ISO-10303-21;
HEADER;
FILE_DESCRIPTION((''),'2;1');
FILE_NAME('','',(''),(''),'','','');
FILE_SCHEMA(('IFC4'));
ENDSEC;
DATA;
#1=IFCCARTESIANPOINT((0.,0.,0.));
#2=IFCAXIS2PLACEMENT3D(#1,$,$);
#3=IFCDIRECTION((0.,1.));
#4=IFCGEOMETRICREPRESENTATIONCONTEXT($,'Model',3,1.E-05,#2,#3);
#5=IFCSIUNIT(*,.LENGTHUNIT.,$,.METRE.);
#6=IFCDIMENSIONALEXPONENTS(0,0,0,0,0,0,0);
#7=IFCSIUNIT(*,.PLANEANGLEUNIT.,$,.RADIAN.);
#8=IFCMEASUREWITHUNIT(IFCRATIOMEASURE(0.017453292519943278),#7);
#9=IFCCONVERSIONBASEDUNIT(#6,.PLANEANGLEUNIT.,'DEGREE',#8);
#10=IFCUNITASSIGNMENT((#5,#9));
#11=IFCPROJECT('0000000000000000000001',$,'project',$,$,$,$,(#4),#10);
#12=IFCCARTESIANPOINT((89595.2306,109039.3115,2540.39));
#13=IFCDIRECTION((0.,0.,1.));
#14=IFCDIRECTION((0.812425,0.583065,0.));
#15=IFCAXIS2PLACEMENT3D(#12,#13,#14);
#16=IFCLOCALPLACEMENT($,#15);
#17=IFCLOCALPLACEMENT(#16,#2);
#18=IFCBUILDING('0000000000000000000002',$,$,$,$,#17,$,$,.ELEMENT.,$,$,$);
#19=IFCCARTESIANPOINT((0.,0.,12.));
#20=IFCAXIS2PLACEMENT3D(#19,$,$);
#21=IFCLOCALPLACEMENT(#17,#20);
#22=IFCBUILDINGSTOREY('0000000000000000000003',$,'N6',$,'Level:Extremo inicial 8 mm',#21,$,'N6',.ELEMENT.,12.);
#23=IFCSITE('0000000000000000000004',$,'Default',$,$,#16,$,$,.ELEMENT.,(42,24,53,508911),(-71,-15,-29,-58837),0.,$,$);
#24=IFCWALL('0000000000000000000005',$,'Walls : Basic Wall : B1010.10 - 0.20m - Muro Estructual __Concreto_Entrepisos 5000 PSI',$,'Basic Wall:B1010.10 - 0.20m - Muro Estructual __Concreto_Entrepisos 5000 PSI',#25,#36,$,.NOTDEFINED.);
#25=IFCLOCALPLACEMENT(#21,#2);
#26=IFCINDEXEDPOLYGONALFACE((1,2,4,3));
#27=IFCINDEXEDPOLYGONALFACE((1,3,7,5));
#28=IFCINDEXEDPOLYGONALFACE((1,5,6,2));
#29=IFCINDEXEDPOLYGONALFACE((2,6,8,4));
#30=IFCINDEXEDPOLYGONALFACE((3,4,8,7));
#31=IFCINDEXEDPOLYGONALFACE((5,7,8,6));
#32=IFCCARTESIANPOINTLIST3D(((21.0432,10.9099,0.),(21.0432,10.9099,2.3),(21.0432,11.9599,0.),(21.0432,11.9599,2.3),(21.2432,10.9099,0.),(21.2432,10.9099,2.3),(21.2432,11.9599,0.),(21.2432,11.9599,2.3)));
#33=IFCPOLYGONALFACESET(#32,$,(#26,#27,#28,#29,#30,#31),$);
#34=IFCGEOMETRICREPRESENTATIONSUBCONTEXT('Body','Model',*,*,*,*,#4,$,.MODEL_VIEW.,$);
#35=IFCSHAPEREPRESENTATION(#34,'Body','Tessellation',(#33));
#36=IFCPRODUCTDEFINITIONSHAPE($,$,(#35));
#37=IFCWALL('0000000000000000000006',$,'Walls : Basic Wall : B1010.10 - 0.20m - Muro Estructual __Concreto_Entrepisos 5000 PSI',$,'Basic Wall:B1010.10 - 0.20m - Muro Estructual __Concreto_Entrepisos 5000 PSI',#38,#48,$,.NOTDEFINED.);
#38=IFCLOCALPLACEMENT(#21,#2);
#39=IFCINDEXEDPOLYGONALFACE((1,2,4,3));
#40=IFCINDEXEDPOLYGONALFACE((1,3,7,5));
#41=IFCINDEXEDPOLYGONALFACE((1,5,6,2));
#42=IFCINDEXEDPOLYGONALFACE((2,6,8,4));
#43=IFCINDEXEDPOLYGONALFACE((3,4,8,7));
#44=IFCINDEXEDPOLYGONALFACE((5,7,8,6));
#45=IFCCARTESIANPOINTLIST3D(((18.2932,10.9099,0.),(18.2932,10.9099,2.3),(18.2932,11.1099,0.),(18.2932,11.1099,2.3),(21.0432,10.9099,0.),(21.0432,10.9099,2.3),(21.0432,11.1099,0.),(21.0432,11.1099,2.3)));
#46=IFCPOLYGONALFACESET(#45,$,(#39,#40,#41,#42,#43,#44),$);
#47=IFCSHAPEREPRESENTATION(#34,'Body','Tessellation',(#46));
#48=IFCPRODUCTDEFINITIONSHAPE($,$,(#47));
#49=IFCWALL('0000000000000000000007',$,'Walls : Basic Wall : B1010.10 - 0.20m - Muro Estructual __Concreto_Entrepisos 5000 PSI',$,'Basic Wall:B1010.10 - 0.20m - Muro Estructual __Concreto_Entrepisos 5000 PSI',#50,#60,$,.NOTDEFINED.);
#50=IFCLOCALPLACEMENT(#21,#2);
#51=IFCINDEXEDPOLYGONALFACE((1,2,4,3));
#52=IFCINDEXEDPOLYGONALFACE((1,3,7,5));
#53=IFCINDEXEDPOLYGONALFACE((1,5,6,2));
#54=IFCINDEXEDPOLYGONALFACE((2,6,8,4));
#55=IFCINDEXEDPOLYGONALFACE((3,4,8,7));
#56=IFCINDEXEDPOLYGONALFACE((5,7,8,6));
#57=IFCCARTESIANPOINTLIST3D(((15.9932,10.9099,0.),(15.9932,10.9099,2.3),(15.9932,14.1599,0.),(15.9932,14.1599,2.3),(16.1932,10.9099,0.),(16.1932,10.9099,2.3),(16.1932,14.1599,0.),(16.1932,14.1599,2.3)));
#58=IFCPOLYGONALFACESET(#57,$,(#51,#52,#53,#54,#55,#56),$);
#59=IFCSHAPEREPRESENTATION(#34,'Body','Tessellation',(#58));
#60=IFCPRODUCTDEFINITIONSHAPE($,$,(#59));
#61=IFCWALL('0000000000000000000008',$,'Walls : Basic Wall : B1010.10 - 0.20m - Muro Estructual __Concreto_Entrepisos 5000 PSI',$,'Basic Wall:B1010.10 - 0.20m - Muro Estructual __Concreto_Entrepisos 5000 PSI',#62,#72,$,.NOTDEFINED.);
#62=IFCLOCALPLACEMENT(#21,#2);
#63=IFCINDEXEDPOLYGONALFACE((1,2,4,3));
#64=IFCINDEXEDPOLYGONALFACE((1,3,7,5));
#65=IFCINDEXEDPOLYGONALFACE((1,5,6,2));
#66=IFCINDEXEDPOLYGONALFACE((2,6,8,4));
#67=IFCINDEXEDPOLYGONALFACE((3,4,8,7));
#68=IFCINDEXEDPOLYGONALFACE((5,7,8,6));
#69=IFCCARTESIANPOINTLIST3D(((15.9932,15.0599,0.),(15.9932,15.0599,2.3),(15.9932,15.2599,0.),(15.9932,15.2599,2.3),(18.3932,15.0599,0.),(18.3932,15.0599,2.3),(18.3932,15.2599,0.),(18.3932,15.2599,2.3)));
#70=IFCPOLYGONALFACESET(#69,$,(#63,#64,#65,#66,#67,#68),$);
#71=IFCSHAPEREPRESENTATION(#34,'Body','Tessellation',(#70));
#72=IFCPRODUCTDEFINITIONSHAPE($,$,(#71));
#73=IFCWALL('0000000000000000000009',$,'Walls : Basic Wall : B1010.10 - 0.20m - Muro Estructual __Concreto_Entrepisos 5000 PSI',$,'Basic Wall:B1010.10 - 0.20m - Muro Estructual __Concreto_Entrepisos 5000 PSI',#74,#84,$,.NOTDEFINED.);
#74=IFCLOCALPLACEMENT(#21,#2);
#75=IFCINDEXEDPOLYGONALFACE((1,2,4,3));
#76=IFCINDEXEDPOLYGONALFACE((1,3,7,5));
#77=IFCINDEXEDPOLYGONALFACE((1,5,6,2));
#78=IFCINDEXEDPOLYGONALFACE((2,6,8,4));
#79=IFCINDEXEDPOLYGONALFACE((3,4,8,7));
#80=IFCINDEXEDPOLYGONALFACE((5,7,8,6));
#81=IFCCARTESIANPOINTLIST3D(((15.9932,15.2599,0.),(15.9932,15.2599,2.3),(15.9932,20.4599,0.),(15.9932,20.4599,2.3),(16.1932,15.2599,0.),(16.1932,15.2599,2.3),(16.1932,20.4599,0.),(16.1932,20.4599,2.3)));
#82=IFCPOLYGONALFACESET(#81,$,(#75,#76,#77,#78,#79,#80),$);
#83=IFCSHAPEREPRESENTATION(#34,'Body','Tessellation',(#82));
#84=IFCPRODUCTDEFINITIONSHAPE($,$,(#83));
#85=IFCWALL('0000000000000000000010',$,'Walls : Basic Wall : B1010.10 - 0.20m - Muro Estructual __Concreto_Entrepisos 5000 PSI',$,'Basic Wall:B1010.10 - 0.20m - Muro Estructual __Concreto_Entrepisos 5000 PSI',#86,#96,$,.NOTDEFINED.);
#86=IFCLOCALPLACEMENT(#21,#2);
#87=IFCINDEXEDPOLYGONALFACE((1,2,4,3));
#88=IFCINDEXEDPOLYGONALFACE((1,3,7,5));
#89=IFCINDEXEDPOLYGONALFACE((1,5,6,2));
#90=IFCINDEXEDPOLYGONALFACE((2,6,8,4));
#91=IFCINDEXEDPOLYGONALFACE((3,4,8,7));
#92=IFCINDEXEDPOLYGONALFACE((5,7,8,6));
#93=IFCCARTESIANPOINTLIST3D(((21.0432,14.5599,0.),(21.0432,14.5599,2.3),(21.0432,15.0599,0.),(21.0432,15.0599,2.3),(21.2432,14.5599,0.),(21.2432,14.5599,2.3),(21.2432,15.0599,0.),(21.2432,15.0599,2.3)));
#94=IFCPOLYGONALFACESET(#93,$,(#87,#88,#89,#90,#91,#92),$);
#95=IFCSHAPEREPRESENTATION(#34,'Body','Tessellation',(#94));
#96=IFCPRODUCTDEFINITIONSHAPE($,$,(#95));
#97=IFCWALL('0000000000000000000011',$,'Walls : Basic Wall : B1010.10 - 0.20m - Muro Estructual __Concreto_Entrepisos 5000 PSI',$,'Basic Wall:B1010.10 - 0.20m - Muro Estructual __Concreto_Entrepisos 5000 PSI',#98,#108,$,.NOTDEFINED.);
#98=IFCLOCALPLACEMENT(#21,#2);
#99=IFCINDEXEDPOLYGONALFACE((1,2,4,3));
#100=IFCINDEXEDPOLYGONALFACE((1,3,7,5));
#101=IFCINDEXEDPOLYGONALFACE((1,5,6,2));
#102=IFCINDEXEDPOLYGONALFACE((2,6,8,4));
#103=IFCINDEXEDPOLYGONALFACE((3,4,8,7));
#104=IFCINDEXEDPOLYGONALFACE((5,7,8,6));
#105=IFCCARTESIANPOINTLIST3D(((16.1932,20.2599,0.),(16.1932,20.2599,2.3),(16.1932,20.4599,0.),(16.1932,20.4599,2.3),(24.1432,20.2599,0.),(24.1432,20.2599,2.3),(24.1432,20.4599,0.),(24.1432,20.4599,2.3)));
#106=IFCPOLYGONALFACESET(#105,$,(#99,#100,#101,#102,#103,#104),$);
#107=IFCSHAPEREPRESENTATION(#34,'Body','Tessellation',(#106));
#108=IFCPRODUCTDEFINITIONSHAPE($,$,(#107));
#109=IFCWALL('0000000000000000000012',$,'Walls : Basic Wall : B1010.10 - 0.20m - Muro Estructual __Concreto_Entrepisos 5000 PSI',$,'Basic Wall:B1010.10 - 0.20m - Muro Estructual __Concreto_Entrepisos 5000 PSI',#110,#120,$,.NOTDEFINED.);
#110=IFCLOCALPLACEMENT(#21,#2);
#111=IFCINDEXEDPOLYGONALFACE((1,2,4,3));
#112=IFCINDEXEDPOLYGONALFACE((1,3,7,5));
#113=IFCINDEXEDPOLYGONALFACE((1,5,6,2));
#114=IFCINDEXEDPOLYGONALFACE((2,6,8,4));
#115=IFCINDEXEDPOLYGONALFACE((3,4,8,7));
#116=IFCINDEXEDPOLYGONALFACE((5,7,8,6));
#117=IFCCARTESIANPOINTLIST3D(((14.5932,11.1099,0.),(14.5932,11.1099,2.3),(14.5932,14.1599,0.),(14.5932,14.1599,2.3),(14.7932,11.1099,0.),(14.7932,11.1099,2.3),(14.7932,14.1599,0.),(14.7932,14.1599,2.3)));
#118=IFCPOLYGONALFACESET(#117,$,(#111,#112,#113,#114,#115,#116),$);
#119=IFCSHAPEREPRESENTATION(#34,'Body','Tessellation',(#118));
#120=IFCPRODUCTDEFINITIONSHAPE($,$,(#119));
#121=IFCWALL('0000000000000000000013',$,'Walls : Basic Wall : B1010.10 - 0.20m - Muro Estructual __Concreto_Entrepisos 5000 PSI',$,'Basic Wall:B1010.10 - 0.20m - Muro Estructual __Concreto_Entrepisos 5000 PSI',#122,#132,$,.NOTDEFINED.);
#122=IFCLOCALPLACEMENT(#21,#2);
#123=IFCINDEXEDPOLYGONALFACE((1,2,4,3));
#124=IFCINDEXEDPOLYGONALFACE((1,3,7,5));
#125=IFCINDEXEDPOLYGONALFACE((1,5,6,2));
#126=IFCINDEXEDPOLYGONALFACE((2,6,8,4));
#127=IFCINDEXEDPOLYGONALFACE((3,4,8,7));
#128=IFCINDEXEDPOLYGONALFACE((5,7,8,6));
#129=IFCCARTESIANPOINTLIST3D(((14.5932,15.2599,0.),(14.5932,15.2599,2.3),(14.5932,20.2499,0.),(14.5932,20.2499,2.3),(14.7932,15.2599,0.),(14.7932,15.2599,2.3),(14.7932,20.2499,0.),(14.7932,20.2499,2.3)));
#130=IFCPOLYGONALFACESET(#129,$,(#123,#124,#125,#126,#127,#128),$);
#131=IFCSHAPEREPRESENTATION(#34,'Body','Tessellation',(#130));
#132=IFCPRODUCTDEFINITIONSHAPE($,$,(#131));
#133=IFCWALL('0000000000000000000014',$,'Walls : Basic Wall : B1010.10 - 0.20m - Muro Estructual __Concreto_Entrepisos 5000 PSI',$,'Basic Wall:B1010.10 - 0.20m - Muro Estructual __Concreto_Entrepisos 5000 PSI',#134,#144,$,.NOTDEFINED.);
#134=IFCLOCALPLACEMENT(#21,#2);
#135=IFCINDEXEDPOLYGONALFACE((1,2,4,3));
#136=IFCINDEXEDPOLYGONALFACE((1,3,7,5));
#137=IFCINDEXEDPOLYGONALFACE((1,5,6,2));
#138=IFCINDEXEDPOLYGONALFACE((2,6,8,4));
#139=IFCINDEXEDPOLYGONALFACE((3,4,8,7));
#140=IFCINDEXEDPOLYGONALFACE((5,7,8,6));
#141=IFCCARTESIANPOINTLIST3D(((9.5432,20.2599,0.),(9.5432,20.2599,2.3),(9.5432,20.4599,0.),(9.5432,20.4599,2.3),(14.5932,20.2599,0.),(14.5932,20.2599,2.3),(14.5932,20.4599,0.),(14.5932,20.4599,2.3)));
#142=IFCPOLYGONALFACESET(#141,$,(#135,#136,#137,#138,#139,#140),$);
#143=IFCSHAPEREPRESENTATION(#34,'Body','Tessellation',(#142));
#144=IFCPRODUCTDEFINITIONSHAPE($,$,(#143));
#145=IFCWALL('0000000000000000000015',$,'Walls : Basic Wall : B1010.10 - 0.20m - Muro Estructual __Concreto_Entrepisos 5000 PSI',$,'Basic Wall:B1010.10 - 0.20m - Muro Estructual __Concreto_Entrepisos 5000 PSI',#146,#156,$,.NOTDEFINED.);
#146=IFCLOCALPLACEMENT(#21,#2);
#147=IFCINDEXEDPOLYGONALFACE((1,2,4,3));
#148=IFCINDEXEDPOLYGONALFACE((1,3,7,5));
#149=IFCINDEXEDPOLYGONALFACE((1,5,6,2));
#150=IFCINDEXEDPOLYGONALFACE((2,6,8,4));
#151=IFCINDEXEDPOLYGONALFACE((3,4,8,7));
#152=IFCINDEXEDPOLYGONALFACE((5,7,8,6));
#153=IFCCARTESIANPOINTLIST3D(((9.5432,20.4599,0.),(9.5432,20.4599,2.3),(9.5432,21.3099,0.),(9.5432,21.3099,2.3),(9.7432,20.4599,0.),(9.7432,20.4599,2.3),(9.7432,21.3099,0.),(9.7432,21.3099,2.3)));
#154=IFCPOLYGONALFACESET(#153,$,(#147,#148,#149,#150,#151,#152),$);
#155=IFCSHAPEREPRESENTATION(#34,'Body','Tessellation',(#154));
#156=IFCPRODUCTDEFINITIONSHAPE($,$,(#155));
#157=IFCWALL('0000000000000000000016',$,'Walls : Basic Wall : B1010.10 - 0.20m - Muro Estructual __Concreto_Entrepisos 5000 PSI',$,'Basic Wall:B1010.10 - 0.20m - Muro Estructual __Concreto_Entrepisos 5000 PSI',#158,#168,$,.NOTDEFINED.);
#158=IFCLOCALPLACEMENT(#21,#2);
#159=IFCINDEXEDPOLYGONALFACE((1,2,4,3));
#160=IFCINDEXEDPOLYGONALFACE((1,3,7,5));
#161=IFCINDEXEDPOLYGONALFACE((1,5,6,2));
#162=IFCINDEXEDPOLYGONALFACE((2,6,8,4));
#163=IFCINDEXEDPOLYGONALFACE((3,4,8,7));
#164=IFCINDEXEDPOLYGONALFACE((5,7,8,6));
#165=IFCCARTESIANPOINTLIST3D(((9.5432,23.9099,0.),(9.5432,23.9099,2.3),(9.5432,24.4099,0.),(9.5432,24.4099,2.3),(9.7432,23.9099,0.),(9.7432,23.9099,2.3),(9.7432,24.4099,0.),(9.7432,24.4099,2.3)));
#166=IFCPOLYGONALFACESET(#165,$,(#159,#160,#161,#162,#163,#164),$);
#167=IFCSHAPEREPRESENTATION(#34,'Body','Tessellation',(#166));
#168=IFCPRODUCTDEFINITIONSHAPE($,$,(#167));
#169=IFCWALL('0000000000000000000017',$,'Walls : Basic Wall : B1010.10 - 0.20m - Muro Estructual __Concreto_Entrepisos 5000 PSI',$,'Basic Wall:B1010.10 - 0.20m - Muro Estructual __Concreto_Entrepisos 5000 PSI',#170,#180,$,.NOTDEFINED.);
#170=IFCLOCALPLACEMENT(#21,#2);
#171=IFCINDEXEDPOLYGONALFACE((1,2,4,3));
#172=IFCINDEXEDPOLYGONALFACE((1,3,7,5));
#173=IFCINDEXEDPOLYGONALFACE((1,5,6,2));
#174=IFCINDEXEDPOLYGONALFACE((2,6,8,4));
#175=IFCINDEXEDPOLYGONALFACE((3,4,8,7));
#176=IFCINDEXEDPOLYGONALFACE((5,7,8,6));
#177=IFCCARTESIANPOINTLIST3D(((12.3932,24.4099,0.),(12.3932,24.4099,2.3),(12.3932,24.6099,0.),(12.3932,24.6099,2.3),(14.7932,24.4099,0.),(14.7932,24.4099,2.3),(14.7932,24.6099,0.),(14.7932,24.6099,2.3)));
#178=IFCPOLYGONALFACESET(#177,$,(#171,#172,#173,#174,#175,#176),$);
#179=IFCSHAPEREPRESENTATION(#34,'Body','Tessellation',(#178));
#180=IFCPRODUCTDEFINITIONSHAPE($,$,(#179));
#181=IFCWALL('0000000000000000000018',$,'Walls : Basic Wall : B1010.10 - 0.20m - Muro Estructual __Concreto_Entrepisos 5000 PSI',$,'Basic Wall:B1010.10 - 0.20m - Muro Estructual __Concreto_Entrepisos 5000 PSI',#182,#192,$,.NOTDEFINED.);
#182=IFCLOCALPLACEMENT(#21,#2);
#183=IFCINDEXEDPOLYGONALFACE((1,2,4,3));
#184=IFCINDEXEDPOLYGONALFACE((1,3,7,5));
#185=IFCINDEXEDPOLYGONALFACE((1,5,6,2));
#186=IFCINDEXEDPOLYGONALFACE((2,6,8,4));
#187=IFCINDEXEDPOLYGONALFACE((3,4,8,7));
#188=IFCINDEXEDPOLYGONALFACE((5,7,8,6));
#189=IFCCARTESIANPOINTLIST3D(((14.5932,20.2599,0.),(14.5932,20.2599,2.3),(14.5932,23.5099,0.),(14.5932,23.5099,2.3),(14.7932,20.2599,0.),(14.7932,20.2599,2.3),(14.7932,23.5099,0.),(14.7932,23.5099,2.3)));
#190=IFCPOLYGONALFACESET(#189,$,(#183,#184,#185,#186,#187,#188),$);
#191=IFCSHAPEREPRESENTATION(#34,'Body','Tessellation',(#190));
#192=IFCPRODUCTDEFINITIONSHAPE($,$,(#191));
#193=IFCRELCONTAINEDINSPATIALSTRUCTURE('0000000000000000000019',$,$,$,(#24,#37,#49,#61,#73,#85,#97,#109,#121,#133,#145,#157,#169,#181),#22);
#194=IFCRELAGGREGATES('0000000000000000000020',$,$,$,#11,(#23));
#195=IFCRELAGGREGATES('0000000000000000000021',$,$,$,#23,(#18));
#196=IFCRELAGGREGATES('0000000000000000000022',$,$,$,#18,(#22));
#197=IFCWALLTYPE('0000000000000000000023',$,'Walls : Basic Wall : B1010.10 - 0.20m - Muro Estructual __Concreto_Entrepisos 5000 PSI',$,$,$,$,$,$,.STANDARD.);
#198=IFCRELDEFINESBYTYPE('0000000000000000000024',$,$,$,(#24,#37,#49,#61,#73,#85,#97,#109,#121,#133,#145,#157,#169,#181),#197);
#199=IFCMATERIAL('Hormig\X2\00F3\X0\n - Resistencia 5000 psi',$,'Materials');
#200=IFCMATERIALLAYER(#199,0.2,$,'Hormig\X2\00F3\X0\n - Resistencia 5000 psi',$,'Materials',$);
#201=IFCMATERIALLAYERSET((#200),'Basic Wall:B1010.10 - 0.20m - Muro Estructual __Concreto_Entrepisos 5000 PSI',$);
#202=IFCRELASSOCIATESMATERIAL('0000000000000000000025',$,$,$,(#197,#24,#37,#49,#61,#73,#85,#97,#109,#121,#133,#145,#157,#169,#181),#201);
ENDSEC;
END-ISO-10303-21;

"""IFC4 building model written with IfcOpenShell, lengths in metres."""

from ifc_helpers import new_model, entity, si_unit, converted_unit, direction, frame, frame_2d, origin, place, context, subcontext, project, spatial, rectangle, extrude, material, layer, layer_set, layer_usage, type_object, element, save


model = new_model("IFC4")

# Units and contexts
model_context = context("Model", 3, precision=1e-05, world=origin(), true_north=direction((0.0, 1.0)))
body_context = subcontext(model_context, "Body", "Model", "MODEL_VIEW")
ifc_project = project(units=[si_unit("LENGTHUNIT", "METRE"), converted_unit("PLANEANGLEUNIT", "DEGREE", entity("IfcRatioMeasure", 0.017453292519943278), si_unit("PLANEANGLEUNIT", "RADIAN"), dimensions=[0, 0, 0, 0, 0, 0, 0])], contexts=[model_context])

# Site, building, storey
site_placement = place(None, frame((89595.2306, 109039.3115, 2540.39), z_axis=(0.0, 0.0, 1.0), x_axis=(0.812425, 0.583065, 0.0)))
site = spatial("IfcSite", under=ifc_project, at=site_placement, Name="Default", CompositionType="ELEMENT", RefLatitude=(42, 24, 53, 508911), RefLongitude=(-71, -15, -29, -58837), RefElevation=0.0)
building_placement = place(site_placement, origin())
building = spatial("IfcBuilding", under=site, at=building_placement, CompositionType="ELEMENT")
storey_placement = place(building_placement, frame((0.0, 0.0, 12.0)))
storey = spatial("IfcBuildingStorey", under=building, at=storey_placement, Name="N6", ObjectType="Level:Extremo inicial 8 mm", LongName="N6", CompositionType="ELEMENT", Elevation=12.0)

# Walls
ifc_material = material(Name="Hormigón - Resistencia 5000 psi", Category="Materials")
ifc_layer_1 = layer(ifc_material, 0.2, Name="Hormigón - Resistencia 5000 psi", Category="Materials")
ifc_layer_set_1 = layer_set([ifc_layer_1], Name="Basic Wall:B1010.10 - 0.20m - Muro Estructual __Concreto_Entrepisos 5000 PSI")
ifc_layer_usage_1 = layer_usage(ifc_layer_set_1, "AXIS2", "NEGATIVE", 0.1)
wall_type_1 = type_object("IfcWallType", Name="Walls : Basic Wall : B1010.10 - 0.20m - Muro Estructual __Concreto_Entrepisos 5000 PSI", PredefinedType="STANDARD", material=ifc_layer_set_1)
wall_1_placement = place(storey_placement, frame((21.1432, 11.9599, 0.0), z_axis=(0.0, 0.0, 1.0), x_axis=(0.0, -1.0, 0.0)))
element("IfcWall", 1, at=wall_1_placement, inside=storey, type_object=wall_type_1, material=ifc_layer_usage_1, Name="Walls : Basic Wall : B1010.10 - 0.20m - Muro Estructual __Concreto_Entrepisos 5000 PSI", ObjectType="Basic Wall:B1010.10 - 0.20m - Muro Estructual __Concreto_Entrepisos 5000 PSI", PredefinedType="NOTDEFINED", context=body_context, shape_type="SweptSolid", body=[
    extrude(rectangle(XDim=1.05, YDim=0.2, at=frame_2d((0.525, 0.0), x_axis=(-1.0, 0.0))), origin(), (0.0, 0.0, 1.0), 2.3),
])
ifc_layer_usage_2 = layer_usage(ifc_layer_set_1, "AXIS2", "NEGATIVE", 0.1)
wall_2_placement = place(storey_placement, frame((21.0432, 11.0099, 0.0), z_axis=(0.0, 0.0, 1.0), x_axis=(-1.0, 0.0, 0.0)))
element("IfcWall", 2, at=wall_2_placement, inside=storey, type_object=wall_type_1, material=ifc_layer_usage_2, Name="Walls : Basic Wall : B1010.10 - 0.20m - Muro Estructual __Concreto_Entrepisos 5000 PSI", ObjectType="Basic Wall:B1010.10 - 0.20m - Muro Estructual __Concreto_Entrepisos 5000 PSI", PredefinedType="NOTDEFINED", context=body_context, shape_type="SweptSolid", body=[
    extrude(rectangle(XDim=2.75, YDim=0.2, at=frame_2d((1.375, 0.0), x_axis=(-1.0, 0.0))), origin(), (0.0, 0.0, 1.0), 2.3),
])
ifc_layer_usage_3 = layer_usage(ifc_layer_set_1, "AXIS2", "NEGATIVE", 0.1)
wall_3_placement = place(storey_placement, frame((16.0932, 14.1599, 0.0), z_axis=(0.0, 0.0, 1.0), x_axis=(0.0, -1.0, 0.0)))
element("IfcWall", 3, at=wall_3_placement, inside=storey, type_object=wall_type_1, material=ifc_layer_usage_3, Name="Walls : Basic Wall : B1010.10 - 0.20m - Muro Estructual __Concreto_Entrepisos 5000 PSI", ObjectType="Basic Wall:B1010.10 - 0.20m - Muro Estructual __Concreto_Entrepisos 5000 PSI", PredefinedType="NOTDEFINED", context=body_context, shape_type="SweptSolid", body=[
    extrude(rectangle(XDim=3.25, YDim=0.2, at=frame_2d((1.625, 0.0), x_axis=(-1.0, 0.0))), origin(), (0.0, 0.0, 1.0), 2.3),
])
ifc_layer_usage_4 = layer_usage(ifc_layer_set_1, "AXIS2", "NEGATIVE", 0.1)
wall_4_placement = place(storey_placement, frame((18.3932, 15.1599, 0.0), z_axis=(0.0, 0.0, 1.0), x_axis=(-1.0, 0.0, 0.0)))
element("IfcWall", 4, at=wall_4_placement, inside=storey, type_object=wall_type_1, material=ifc_layer_usage_4, Name="Walls : Basic Wall : B1010.10 - 0.20m - Muro Estructual __Concreto_Entrepisos 5000 PSI", ObjectType="Basic Wall:B1010.10 - 0.20m - Muro Estructual __Concreto_Entrepisos 5000 PSI", PredefinedType="NOTDEFINED", context=body_context, shape_type="SweptSolid", body=[
    extrude(rectangle(XDim=2.4, YDim=0.2, at=frame_2d((1.2, 0.0), x_axis=(-1.0, 0.0))), origin(), (0.0, 0.0, 1.0), 2.3),
])
ifc_layer_usage_5 = layer_usage(ifc_layer_set_1, "AXIS2", "NEGATIVE", 0.1)
wall_5_placement = place(storey_placement, frame((16.0932, 15.2599, 0.0), z_axis=(0.0, 0.0, 1.0), x_axis=(0.0, 1.0, 0.0)))
element("IfcWall", 5, at=wall_5_placement, inside=storey, type_object=wall_type_1, material=ifc_layer_usage_5, Name="Walls : Basic Wall : B1010.10 - 0.20m - Muro Estructual __Concreto_Entrepisos 5000 PSI", ObjectType="Basic Wall:B1010.10 - 0.20m - Muro Estructual __Concreto_Entrepisos 5000 PSI", PredefinedType="NOTDEFINED", context=body_context, shape_type="SweptSolid", body=[
    extrude(rectangle(XDim=5.2, YDim=0.2, at=frame_2d((2.6, 0.0), x_axis=(-1.0, 0.0))), origin(), (0.0, 0.0, 1.0), 2.3),
])
ifc_layer_usage_6 = layer_usage(ifc_layer_set_1, "AXIS2", "NEGATIVE", 0.1)
wall_6_placement = place(storey_placement, frame((21.1432, 14.5599, 0.0), z_axis=(0.0, 0.0, 1.0), x_axis=(0.0, 1.0, 0.0)))
element("IfcWall", 6, at=wall_6_placement, inside=storey, type_object=wall_type_1, material=ifc_layer_usage_6, Name="Walls : Basic Wall : B1010.10 - 0.20m - Muro Estructual __Concreto_Entrepisos 5000 PSI", ObjectType="Basic Wall:B1010.10 - 0.20m - Muro Estructual __Concreto_Entrepisos 5000 PSI", PredefinedType="NOTDEFINED", context=body_context, shape_type="SweptSolid", body=[
    extrude(rectangle(XDim=0.5, YDim=0.2, at=frame_2d((0.25, 0.0), x_axis=(-1.0, 0.0))), origin(), (0.0, 0.0, 1.0), 2.3),
])
ifc_layer_usage_7 = layer_usage(ifc_layer_set_1, "AXIS2", "NEGATIVE", 0.1)
wall_7_placement = place(storey_placement, frame((16.1932, 20.3599, 0.0)))
element("IfcWall", 7, at=wall_7_placement, inside=storey, type_object=wall_type_1, material=ifc_layer_usage_7, Name="Walls : Basic Wall : B1010.10 - 0.20m - Muro Estructual __Concreto_Entrepisos 5000 PSI", ObjectType="Basic Wall:B1010.10 - 0.20m - Muro Estructual __Concreto_Entrepisos 5000 PSI", PredefinedType="NOTDEFINED", context=body_context, shape_type="SweptSolid", body=[
    extrude(rectangle(XDim=7.95, YDim=0.2, at=frame_2d((3.975, 0.0), x_axis=(-1.0, 0.0))), origin(), (0.0, 0.0, 1.0), 2.3),
])
ifc_layer_usage_8 = layer_usage(ifc_layer_set_1, "AXIS2", "POSITIVE", -0.1)
wall_8_placement = place(storey_placement, frame((14.6932, 14.1599, 0.0), z_axis=(0.0, 0.0, 1.0), x_axis=(0.0, -1.0, 0.0)))
element("IfcWall", 8, at=wall_8_placement, inside=storey, type_object=wall_type_1, material=ifc_layer_usage_8, Name="Walls : Basic Wall : B1010.10 - 0.20m - Muro Estructual __Concreto_Entrepisos 5000 PSI", ObjectType="Basic Wall:B1010.10 - 0.20m - Muro Estructual __Concreto_Entrepisos 5000 PSI", PredefinedType="NOTDEFINED", context=body_context, shape_type="SweptSolid", body=[
    extrude(rectangle(XDim=3.05, YDim=0.2, at=frame_2d((1.525, 0.0), x_axis=(-1.0, 0.0))), origin(), (0.0, 0.0, 1.0), 2.3),
])
ifc_layer_usage_9 = layer_usage(ifc_layer_set_1, "AXIS2", "POSITIVE", -0.1)
wall_9_placement = place(storey_placement, frame((14.6932, 15.2599, 0.0), z_axis=(0.0, 0.0, 1.0), x_axis=(0.0, 1.0, 0.0)))
element("IfcWall", 9, at=wall_9_placement, inside=storey, type_object=wall_type_1, material=ifc_layer_usage_9, Name="Walls : Basic Wall : B1010.10 - 0.20m - Muro Estructual __Concreto_Entrepisos 5000 PSI", ObjectType="Basic Wall:B1010.10 - 0.20m - Muro Estructual __Concreto_Entrepisos 5000 PSI", PredefinedType="NOTDEFINED", context=body_context, shape_type="SweptSolid", body=[
    extrude(rectangle(XDim=4.99, YDim=0.2, at=frame_2d((2.495, 0.0), x_axis=(-1.0, 0.0))), origin(), (0.0, 0.0, 1.0), 2.3),
])
ifc_layer_usage_10 = layer_usage(ifc_layer_set_1, "AXIS2", "POSITIVE", -0.1)
wall_10_placement = place(storey_placement, frame((14.5932, 20.3599, 0.0), z_axis=(0.0, 0.0, 1.0), x_axis=(-1.0, 0.0, 0.0)))
element("IfcWall", 10, at=wall_10_placement, inside=storey, type_object=wall_type_1, material=ifc_layer_usage_10, Name="Walls : Basic Wall : B1010.10 - 0.20m - Muro Estructual __Concreto_Entrepisos 5000 PSI", ObjectType="Basic Wall:B1010.10 - 0.20m - Muro Estructual __Concreto_Entrepisos 5000 PSI", PredefinedType="NOTDEFINED", context=body_context, shape_type="SweptSolid", body=[
    extrude(rectangle(XDim=5.05, YDim=0.2, at=frame_2d((2.525, 0.0), x_axis=(-1.0, 0.0))), origin(), (0.0, 0.0, 1.0), 2.3),
])
ifc_layer_usage_11 = layer_usage(ifc_layer_set_1, "AXIS2", "NEGATIVE", 0.1)
wall_11_placement = place(storey_placement, frame((9.6432, 20.4599, 0.0), z_axis=(0.0, 0.0, 1.0), x_axis=(0.0, 1.0, 0.0)))
element("IfcWall", 11, at=wall_11_placement, inside=storey, type_object=wall_type_1, material=ifc_layer_usage_11, Name="Walls : Basic Wall : B1010.10 - 0.20m - Muro Estructual __Concreto_Entrepisos 5000 PSI", ObjectType="Basic Wall:B1010.10 - 0.20m - Muro Estructual __Concreto_Entrepisos 5000 PSI", PredefinedType="NOTDEFINED", context=body_context, shape_type="SweptSolid", body=[
    extrude(rectangle(XDim=0.85, YDim=0.2, at=frame_2d((0.425, 0.0), x_axis=(-1.0, 0.0))), origin(), (0.0, 0.0, 1.0), 2.3),
])
ifc_layer_usage_12 = layer_usage(ifc_layer_set_1, "AXIS2", "NEGATIVE", 0.1)
wall_12_placement = place(storey_placement, frame((9.6432, 23.9099, 0.0), z_axis=(0.0, 0.0, 1.0), x_axis=(0.0, 1.0, 0.0)))
element("IfcWall", 12, at=wall_12_placement, inside=storey, type_object=wall_type_1, material=ifc_layer_usage_12, Name="Walls : Basic Wall : B1010.10 - 0.20m - Muro Estructual __Concreto_Entrepisos 5000 PSI", ObjectType="Basic Wall:B1010.10 - 0.20m - Muro Estructual __Concreto_Entrepisos 5000 PSI", PredefinedType="NOTDEFINED", context=body_context, shape_type="SweptSolid", body=[
    extrude(rectangle(XDim=0.5, YDim=0.2, at=frame_2d((0.25, 0.0), x_axis=(-1.0, 0.0))), origin(), (0.0, 0.0, 1.0), 2.3),
])
ifc_layer_usage_13 = layer_usage(ifc_layer_set_1, "AXIS2", "NEGATIVE", 0.1)
wall_13_placement = place(storey_placement, frame((12.3932, 24.5099, 0.0)))
element("IfcWall", 13, at=wall_13_placement, inside=storey, type_object=wall_type_1, material=ifc_layer_usage_13, Name="Walls : Basic Wall : B1010.10 - 0.20m - Muro Estructual __Concreto_Entrepisos 5000 PSI", ObjectType="Basic Wall:B1010.10 - 0.20m - Muro Estructual __Concreto_Entrepisos 5000 PSI", PredefinedType="NOTDEFINED", context=body_context, shape_type="SweptSolid", body=[
    extrude(rectangle(XDim=2.4, YDim=0.2, at=frame_2d((1.2, 0.0), x_axis=(-1.0, 0.0))), origin(), (0.0, 0.0, 1.0), 2.3),
])
ifc_layer_usage_14 = layer_usage(ifc_layer_set_1, "AXIS2", "POSITIVE", -0.1)
wall_14_placement = place(storey_placement, frame((14.6932, 20.2599, 0.0), z_axis=(0.0, 0.0, 1.0), x_axis=(0.0, 1.0, 0.0)))
element("IfcWall", 14, at=wall_14_placement, inside=storey, type_object=wall_type_1, material=ifc_layer_usage_14, Name="Walls : Basic Wall : B1010.10 - 0.20m - Muro Estructual __Concreto_Entrepisos 5000 PSI", ObjectType="Basic Wall:B1010.10 - 0.20m - Muro Estructual __Concreto_Entrepisos 5000 PSI", PredefinedType="NOTDEFINED", context=body_context, shape_type="SweptSolid", body=[
    extrude(rectangle(XDim=3.25, YDim=0.2, at=frame_2d((1.625, 0.0), x_axis=(-1.0, 0.0))), origin(), (0.0, 0.0, 1.0), 2.3),
])

save(model, "model.ifc")
